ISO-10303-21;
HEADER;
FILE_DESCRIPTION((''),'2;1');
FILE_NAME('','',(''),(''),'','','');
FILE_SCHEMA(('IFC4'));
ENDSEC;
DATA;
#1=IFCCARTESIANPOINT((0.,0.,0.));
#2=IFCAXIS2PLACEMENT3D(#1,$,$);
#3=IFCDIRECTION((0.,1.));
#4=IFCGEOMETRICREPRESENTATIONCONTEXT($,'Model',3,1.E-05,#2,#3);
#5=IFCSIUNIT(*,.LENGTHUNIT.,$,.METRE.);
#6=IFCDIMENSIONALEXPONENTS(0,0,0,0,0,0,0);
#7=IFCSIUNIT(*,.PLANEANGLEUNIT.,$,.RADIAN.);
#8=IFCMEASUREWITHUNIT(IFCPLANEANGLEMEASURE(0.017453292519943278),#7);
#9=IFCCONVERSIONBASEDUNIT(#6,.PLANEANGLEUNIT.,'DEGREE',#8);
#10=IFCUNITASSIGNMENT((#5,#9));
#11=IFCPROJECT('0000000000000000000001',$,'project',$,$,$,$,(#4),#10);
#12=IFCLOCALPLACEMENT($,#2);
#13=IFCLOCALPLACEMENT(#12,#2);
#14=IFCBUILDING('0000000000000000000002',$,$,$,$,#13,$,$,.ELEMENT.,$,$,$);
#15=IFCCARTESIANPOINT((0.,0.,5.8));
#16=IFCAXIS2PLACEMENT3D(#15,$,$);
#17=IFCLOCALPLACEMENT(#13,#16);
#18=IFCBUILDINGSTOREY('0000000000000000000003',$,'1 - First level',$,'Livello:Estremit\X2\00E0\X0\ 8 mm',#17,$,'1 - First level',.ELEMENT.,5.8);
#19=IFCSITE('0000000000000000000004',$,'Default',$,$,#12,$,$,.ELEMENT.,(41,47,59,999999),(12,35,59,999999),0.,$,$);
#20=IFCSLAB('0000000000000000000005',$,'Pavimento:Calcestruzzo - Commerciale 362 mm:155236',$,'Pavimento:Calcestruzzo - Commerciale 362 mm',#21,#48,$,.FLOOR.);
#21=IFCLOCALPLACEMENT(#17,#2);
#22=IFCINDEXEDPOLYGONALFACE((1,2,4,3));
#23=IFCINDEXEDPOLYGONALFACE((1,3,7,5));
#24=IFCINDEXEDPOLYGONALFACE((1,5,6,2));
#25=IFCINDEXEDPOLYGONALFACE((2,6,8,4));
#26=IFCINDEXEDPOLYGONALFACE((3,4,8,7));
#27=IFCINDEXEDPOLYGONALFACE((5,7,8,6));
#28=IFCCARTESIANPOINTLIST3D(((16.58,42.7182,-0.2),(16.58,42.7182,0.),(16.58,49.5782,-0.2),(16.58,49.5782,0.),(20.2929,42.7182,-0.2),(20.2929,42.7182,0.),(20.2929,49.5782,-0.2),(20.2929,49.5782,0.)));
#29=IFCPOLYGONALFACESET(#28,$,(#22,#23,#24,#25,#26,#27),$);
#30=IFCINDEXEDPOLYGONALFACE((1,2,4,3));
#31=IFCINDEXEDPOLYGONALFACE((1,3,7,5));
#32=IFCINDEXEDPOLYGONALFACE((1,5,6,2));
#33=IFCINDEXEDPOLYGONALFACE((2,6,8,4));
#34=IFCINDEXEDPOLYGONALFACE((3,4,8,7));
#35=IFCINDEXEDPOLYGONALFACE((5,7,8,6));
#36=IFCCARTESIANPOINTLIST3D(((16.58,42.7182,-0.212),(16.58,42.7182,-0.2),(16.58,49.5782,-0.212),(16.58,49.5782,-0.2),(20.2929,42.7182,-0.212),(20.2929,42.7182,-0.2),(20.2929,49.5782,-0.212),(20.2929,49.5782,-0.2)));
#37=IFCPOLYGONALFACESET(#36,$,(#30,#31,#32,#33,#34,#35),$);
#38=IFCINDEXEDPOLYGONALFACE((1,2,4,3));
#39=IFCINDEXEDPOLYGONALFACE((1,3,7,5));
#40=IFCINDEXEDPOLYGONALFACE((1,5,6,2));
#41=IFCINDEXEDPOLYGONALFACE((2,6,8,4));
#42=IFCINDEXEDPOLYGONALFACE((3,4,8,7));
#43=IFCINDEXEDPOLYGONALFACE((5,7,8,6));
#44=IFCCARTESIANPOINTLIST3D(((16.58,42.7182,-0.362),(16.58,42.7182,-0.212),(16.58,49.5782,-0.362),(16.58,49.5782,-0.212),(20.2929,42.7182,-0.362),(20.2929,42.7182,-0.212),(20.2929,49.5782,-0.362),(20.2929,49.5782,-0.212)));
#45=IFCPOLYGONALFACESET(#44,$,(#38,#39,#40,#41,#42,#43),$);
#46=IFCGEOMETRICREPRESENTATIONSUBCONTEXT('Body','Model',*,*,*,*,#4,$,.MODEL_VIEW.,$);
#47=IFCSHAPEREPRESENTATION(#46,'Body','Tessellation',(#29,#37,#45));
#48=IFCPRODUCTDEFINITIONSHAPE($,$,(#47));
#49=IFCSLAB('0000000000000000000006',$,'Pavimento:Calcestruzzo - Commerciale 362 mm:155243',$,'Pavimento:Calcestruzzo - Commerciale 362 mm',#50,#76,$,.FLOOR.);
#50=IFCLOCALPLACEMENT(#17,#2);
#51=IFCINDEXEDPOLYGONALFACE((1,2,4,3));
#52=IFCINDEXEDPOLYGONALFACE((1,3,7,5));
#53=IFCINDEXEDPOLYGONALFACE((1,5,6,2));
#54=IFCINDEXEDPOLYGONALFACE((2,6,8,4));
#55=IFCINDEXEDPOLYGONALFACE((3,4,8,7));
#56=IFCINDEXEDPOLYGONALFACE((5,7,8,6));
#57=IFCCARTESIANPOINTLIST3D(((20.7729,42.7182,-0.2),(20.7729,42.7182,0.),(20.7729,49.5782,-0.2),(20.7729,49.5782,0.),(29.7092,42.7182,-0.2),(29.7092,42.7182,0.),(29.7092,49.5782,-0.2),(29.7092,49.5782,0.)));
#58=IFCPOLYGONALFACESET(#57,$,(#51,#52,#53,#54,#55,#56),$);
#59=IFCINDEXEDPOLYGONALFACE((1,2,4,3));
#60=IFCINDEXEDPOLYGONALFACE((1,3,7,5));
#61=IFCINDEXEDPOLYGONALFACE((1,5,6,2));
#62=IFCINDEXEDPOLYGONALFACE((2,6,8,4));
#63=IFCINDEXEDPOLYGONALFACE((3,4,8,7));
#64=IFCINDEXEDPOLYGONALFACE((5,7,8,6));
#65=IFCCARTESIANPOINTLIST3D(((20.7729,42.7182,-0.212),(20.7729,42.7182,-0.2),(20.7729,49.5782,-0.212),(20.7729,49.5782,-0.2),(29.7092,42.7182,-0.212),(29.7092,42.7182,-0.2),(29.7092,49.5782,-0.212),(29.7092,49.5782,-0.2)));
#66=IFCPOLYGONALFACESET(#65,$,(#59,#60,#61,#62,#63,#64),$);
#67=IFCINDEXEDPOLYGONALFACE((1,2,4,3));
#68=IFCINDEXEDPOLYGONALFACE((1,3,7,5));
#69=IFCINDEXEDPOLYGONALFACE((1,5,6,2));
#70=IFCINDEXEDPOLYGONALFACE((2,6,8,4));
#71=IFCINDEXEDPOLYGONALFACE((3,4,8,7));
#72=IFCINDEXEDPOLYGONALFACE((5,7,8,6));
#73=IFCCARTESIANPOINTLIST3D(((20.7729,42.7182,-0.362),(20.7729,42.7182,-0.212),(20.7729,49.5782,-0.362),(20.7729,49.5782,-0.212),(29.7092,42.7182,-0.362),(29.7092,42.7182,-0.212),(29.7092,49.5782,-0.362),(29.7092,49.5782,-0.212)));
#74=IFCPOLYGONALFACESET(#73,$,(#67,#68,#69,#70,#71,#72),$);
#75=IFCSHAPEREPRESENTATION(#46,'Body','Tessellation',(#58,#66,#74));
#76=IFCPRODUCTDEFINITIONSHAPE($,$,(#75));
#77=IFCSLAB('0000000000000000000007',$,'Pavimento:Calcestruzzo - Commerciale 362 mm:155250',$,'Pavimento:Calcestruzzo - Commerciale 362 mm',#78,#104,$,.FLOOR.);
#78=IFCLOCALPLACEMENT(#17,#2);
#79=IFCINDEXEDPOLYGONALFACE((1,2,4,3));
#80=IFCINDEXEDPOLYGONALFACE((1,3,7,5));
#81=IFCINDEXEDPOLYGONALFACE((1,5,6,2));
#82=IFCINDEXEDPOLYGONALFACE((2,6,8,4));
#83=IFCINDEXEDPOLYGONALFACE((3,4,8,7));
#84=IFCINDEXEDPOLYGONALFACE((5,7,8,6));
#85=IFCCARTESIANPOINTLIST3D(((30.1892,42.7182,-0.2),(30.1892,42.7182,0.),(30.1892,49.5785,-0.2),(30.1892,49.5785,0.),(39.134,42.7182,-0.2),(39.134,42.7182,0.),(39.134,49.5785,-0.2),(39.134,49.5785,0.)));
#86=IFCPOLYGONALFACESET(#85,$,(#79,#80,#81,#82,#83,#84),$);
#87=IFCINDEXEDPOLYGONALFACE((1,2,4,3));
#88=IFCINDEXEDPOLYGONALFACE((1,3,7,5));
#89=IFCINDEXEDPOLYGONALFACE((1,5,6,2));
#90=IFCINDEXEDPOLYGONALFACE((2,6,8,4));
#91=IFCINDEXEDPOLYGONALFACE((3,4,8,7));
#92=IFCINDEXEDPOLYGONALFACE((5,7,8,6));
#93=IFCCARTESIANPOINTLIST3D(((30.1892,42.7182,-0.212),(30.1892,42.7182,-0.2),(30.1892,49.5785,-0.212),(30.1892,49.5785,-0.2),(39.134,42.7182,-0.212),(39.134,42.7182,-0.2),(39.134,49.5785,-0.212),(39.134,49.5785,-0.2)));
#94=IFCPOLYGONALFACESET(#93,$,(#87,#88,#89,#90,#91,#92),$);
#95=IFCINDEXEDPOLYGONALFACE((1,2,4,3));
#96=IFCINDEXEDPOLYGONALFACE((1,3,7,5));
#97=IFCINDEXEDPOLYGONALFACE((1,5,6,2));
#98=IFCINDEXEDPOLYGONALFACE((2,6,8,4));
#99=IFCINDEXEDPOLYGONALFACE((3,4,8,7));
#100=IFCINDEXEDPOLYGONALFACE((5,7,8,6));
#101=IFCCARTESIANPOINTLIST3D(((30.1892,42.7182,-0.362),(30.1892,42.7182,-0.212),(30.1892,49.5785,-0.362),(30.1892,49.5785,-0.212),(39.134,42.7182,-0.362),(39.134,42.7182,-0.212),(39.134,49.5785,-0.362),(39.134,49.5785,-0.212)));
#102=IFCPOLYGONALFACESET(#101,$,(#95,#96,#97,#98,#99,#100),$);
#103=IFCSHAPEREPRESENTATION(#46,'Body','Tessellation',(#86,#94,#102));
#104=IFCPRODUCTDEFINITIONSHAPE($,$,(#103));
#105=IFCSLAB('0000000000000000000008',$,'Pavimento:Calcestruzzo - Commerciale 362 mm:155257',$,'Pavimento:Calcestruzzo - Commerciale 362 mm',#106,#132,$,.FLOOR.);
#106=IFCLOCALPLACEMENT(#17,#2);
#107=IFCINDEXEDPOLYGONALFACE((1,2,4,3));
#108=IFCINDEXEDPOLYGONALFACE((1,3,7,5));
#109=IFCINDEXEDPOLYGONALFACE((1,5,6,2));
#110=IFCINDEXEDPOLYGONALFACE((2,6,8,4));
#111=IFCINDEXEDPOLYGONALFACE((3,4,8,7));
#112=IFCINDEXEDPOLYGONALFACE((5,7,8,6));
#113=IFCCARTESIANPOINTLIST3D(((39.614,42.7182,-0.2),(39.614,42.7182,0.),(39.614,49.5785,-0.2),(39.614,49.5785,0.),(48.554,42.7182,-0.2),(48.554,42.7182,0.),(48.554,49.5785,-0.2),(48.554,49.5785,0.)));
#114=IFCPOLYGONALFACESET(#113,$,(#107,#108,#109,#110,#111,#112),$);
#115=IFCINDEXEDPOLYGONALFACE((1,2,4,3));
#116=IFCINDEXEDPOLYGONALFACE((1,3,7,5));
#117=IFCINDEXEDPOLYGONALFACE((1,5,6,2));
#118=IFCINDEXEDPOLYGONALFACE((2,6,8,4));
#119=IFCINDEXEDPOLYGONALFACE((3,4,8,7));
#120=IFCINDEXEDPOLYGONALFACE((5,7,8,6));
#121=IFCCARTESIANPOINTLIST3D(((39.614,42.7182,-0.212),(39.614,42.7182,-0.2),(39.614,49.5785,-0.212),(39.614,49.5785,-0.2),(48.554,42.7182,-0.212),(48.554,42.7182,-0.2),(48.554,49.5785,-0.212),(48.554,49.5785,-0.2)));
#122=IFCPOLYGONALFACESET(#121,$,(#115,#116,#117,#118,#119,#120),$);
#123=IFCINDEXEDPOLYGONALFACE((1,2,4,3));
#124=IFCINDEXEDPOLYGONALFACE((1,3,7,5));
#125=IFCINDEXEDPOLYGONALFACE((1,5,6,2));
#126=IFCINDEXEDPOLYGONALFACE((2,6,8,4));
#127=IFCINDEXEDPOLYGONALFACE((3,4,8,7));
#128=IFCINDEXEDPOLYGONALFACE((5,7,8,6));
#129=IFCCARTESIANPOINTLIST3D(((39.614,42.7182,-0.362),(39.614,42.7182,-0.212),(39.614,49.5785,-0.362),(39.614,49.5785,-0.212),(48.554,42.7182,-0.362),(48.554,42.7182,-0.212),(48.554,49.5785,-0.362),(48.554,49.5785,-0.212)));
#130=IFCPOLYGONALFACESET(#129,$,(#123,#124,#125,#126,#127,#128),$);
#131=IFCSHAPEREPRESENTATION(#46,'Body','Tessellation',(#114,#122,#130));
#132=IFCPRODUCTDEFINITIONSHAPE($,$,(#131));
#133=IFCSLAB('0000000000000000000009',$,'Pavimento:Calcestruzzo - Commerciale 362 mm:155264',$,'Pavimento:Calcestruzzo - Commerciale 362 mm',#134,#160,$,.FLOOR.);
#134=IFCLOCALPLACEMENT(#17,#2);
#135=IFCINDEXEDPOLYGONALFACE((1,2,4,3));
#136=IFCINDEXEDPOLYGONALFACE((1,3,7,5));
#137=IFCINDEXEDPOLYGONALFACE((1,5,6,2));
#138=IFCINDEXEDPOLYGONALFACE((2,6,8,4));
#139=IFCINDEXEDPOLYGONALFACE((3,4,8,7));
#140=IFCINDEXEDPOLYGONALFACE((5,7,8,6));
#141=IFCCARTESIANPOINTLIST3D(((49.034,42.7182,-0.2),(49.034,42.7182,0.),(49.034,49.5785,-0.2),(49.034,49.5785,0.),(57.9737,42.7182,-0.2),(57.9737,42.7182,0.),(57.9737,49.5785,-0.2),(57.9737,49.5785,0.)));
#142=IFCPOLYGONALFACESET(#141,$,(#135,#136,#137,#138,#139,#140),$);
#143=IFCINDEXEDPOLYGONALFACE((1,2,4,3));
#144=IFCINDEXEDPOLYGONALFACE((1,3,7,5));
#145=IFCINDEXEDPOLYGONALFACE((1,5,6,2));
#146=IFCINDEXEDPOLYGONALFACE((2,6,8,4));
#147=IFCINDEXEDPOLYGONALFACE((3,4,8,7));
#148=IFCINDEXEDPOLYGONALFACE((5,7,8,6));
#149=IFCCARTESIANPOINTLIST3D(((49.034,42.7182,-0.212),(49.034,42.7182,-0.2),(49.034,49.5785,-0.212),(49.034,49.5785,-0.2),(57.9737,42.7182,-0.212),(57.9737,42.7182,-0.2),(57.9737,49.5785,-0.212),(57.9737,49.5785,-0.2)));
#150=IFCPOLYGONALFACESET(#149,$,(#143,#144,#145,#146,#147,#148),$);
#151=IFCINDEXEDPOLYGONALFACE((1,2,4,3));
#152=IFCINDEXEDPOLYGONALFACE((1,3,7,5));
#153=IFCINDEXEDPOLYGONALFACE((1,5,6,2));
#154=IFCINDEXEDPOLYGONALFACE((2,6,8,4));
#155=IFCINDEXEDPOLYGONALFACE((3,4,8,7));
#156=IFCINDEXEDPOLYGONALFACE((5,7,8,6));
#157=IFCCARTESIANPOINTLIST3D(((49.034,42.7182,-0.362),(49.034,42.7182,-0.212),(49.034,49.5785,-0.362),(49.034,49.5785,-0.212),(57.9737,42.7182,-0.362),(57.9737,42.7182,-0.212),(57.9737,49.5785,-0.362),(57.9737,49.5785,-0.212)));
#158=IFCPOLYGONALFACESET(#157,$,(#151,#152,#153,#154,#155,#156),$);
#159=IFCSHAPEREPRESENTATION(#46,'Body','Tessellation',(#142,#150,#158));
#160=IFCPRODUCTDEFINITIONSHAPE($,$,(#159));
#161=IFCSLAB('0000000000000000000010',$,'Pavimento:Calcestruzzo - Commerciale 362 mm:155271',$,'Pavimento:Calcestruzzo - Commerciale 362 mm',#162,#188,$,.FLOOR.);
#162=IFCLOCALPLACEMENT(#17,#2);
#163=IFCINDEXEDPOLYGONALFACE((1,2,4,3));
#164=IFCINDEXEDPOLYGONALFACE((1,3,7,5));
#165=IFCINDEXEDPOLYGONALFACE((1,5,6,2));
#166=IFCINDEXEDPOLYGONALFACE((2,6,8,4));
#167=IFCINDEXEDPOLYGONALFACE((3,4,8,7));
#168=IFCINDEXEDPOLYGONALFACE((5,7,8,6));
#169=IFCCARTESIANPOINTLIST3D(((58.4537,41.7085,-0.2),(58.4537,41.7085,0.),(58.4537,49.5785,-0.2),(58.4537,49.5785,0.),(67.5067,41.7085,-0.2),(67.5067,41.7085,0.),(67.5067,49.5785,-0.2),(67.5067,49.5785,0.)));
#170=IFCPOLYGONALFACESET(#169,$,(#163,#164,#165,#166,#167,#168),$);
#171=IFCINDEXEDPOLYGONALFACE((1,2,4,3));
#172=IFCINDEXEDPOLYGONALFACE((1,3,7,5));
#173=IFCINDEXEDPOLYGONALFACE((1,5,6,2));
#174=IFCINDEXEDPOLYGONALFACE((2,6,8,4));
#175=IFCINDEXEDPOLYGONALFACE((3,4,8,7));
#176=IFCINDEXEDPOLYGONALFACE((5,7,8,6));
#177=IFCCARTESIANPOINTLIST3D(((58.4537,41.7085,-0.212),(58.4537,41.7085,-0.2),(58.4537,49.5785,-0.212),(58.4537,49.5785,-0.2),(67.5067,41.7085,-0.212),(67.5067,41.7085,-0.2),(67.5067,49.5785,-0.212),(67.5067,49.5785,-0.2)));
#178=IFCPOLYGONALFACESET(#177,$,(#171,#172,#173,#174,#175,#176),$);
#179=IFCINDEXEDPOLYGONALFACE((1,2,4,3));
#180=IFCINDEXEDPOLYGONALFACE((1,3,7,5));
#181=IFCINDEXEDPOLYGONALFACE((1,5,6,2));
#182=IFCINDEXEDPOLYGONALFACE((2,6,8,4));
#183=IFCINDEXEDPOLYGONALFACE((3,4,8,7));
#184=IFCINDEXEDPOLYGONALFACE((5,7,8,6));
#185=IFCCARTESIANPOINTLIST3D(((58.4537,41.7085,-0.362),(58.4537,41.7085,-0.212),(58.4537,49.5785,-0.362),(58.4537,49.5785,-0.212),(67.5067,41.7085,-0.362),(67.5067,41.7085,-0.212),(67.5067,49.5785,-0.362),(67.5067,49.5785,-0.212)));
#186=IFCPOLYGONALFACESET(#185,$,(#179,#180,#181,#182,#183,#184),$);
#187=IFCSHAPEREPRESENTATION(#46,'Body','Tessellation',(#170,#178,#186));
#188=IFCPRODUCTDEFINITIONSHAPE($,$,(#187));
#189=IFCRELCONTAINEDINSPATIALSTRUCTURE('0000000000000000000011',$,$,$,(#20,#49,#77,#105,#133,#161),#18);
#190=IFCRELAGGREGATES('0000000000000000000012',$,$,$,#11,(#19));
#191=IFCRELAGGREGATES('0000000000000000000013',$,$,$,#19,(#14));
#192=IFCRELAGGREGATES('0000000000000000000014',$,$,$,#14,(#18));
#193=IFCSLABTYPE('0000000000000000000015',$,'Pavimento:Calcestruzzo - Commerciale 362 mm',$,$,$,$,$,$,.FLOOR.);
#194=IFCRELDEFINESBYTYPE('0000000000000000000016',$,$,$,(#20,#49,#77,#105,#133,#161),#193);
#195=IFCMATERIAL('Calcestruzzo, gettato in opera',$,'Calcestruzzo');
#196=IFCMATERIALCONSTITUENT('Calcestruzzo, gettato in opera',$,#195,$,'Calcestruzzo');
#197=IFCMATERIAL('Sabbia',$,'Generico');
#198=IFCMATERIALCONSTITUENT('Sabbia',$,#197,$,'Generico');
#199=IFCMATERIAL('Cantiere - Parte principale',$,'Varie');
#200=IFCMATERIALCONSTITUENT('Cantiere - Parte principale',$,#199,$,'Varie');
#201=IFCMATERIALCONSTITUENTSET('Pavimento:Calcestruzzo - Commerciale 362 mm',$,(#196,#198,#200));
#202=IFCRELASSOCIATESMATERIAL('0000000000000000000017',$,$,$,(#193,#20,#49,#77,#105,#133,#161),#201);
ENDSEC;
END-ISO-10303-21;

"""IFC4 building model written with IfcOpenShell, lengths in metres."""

from ifc_helpers import new_model, entity, si_unit, converted_unit, direction, frame, origin, place, context, subcontext, project, spatial, indexed_curve, outline, extrude, material, constituent, constituent_set, type_object, element, save


model = new_model("IFC4")

# Units and contexts
model_context = context("Model", 3, precision=1e-05, world=origin(), true_north=direction((0.0, 1.0)))
body_context = subcontext(model_context, "Body", "Model", "MODEL_VIEW")
ifc_project = project(units=[si_unit("LENGTHUNIT", "METRE"), converted_unit("PLANEANGLEUNIT", "DEGREE", entity("IfcPlaneAngleMeasure", 0.017453292519943278), si_unit("PLANEANGLEUNIT", "RADIAN"), dimensions=[0, 0, 0, 0, 0, 0, 0])], contexts=[model_context])

# Site, building, storey
site_placement = place(None, origin())
site = spatial("IfcSite", under=ifc_project, at=site_placement, Name="Default", CompositionType="ELEMENT", RefLatitude=(41, 47, 59, 999999), RefLongitude=(12, 35, 59, 999999), RefElevation=0.0)
building_placement = place(site_placement, origin())
building = spatial("IfcBuilding", under=site, at=building_placement, CompositionType="ELEMENT")
storey_placement = place(building_placement, frame((0.0, 0.0, 5.8)))
storey = spatial("IfcBuildingStorey", under=building, at=storey_placement, Name="1 - First level", ObjectType="Livello:Estremità 8 mm", LongName="1 - First level", CompositionType="ELEMENT", Elevation=5.8)

# Slabs
ifc_material_1 = material(Name="Calcestruzzo, gettato in opera", Category="Calcestruzzo")
ifc_constituent_1 = constituent(ifc_material_1, Name="Calcestruzzo, gettato in opera", Category="Calcestruzzo")
ifc_material_2 = material(Name="Sabbia", Category="Generico")
ifc_constituent_2 = constituent(ifc_material_2, Name="Sabbia", Category="Generico")
ifc_material_3 = material(Name="Cantiere - Parte principale", Category="Varie")
ifc_constituent_3 = constituent(ifc_material_3, Name="Cantiere - Parte principale", Category="Varie")
ifc_constituent_set = constituent_set(constituents=[ifc_constituent_1, ifc_constituent_2, ifc_constituent_3], Name="Pavimento:Calcestruzzo - Commerciale 362 mm")
slab_type = type_object("IfcSlabType", Name="Pavimento:Calcestruzzo - Commerciale 362 mm", PredefinedType="FLOOR", material=ifc_constituent_set)
slab_1_placement = place(storey_placement, origin())
element("IfcSlab", 1, at=slab_1_placement, inside=storey, type_object=slab_type, material=ifc_constituent_set, Name="Pavimento:Calcestruzzo - Commerciale 362 mm:155236", ObjectType="Pavimento:Calcestruzzo - Commerciale 362 mm", PredefinedType="FLOOR", context=body_context, shape_type="SweptSolid", body=[
    extrude(outline(indexed_curve([(-1.8565, -3.43), (1.8565, -3.43), (1.8565, 3.43), (-1.8565, 3.43), (-1.8565, -3.43)], self_intersect=False)), frame((18.4365, 46.1482, -0.2), z_axis=(0.0, 0.0, 1.0), x_axis=(-1.0, 0.0, 0.0)), (0.0, 0.0, 1.0), 0.2),
    extrude(outline(indexed_curve([(-1.8565, -3.43), (1.8565, -3.43), (1.8565, 3.43), (-1.8565, 3.43), (-1.8565, -3.43)], self_intersect=False)), frame((18.4365, 46.1482, -0.212), z_axis=(0.0, 0.0, 1.0), x_axis=(-1.0, 0.0, 0.0)), (0.0, 0.0, 1.0), 0.012),
    extrude(outline(indexed_curve([(-1.8565, -3.43), (1.8565, -3.43), (1.8565, 3.43), (-1.8565, 3.43), (-1.8565, -3.43)], self_intersect=False)), frame((18.4365, 46.1482, -0.362), z_axis=(0.0, 0.0, 1.0), x_axis=(-1.0, 0.0, 0.0)), (0.0, 0.0, 1.0), 0.15),
])
slab_2_placement = place(storey_placement, origin())
element("IfcSlab", 2, at=slab_2_placement, inside=storey, type_object=slab_type, material=ifc_constituent_set, Name="Pavimento:Calcestruzzo - Commerciale 362 mm:155243", ObjectType="Pavimento:Calcestruzzo - Commerciale 362 mm", PredefinedType="FLOOR", context=body_context, shape_type="SweptSolid", body=[
    extrude(outline(indexed_curve([(-3.43, -4.4681), (3.43, -4.4681), (3.43, 4.4681), (-3.43, 4.4681), (-3.43, -4.4681)], self_intersect=False)), frame((25.2411, 46.1482, -0.2), z_axis=(0.0, 0.0, 1.0), x_axis=(0.0, -1.0, 0.0)), (0.0, 0.0, 1.0), 0.2),
    extrude(outline(indexed_curve([(-3.43, -4.4681), (3.43, -4.4681), (3.43, 4.4681), (-3.43, 4.4681), (-3.43, -4.4681)], self_intersect=False)), frame((25.2411, 46.1482, -0.212), z_axis=(0.0, 0.0, 1.0), x_axis=(0.0, -1.0, 0.0)), (0.0, 0.0, 1.0), 0.012),
    extrude(outline(indexed_curve([(-3.43, -4.4681), (3.43, -4.4681), (3.43, 4.4681), (-3.43, 4.4681), (-3.43, -4.4681)], self_intersect=False)), frame((25.2411, 46.1482, -0.362), z_axis=(0.0, 0.0, 1.0), x_axis=(0.0, -1.0, 0.0)), (0.0, 0.0, 1.0), 0.15),
])
slab_3_placement = place(storey_placement, origin())
element("IfcSlab", 3, at=slab_3_placement, inside=storey, type_object=slab_type, material=ifc_constituent_set, Name="Pavimento:Calcestruzzo - Commerciale 362 mm:155250", ObjectType="Pavimento:Calcestruzzo - Commerciale 362 mm", PredefinedType="FLOOR", context=body_context, shape_type="SweptSolid", body=[
    extrude(outline(indexed_curve([(-3.4302, -4.4724), (3.4302, -4.4724), (3.4302, 4.4724), (-3.4302, 4.4724), (-3.4302, -4.4724)], self_intersect=False)), frame((34.6616, 46.1483, -0.2), z_axis=(0.0, 0.0, 1.0), x_axis=(0.0, -1.0, 0.0)), (0.0, 0.0, 1.0), 0.2),
    extrude(outline(indexed_curve([(-3.4302, -4.4724), (3.4302, -4.4724), (3.4302, 4.4724), (-3.4302, 4.4724), (-3.4302, -4.4724)], self_intersect=False)), frame((34.6616, 46.1483, -0.212), z_axis=(0.0, 0.0, 1.0), x_axis=(0.0, -1.0, 0.0)), (0.0, 0.0, 1.0), 0.012),
    extrude(outline(indexed_curve([(-3.4302, -4.4724), (3.4302, -4.4724), (3.4302, 4.4724), (-3.4302, 4.4724), (-3.4302, -4.4724)], self_intersect=False)), frame((34.6616, 46.1483, -0.362), z_axis=(0.0, 0.0, 1.0), x_axis=(0.0, -1.0, 0.0)), (0.0, 0.0, 1.0), 0.15),
])
slab_4_placement = place(storey_placement, origin())
element("IfcSlab", 4, at=slab_4_placement, inside=storey, type_object=slab_type, material=ifc_constituent_set, Name="Pavimento:Calcestruzzo - Commerciale 362 mm:155257", ObjectType="Pavimento:Calcestruzzo - Commerciale 362 mm", PredefinedType="FLOOR", context=body_context, shape_type="SweptSolid", body=[
    extrude(outline(indexed_curve([(-3.4302, -4.47), (3.4302, -4.47), (3.4302, 4.47), (-3.4302, 4.47), (-3.4302, -4.47)], self_intersect=False)), frame((44.084, 46.1483, -0.2), z_axis=(0.0, 0.0, 1.0), x_axis=(0.0, -1.0, 0.0)), (0.0, 0.0, 1.0), 0.2),
    extrude(outline(indexed_curve([(-3.4302, -4.47), (3.4302, -4.47), (3.4302, 4.47), (-3.4302, 4.47), (-3.4302, -4.47)], self_intersect=False)), frame((44.084, 46.1483, -0.212), z_axis=(0.0, 0.0, 1.0), x_axis=(0.0, -1.0, 0.0)), (0.0, 0.0, 1.0), 0.012),
    extrude(outline(indexed_curve([(-3.4302, -4.47), (3.4302, -4.47), (3.4302, 4.47), (-3.4302, 4.47), (-3.4302, -4.47)], self_intersect=False)), frame((44.084, 46.1483, -0.362), z_axis=(0.0, 0.0, 1.0), x_axis=(0.0, -1.0, 0.0)), (0.0, 0.0, 1.0), 0.15),
])
slab_5_placement = place(storey_placement, origin())
element("IfcSlab", 5, at=slab_5_placement, inside=storey, type_object=slab_type, material=ifc_constituent_set, Name="Pavimento:Calcestruzzo - Commerciale 362 mm:155264", ObjectType="Pavimento:Calcestruzzo - Commerciale 362 mm", PredefinedType="FLOOR", context=body_context, shape_type="SweptSolid", body=[
    extrude(outline(indexed_curve([(-3.4302, -4.4698), (3.4302, -4.4698), (3.4302, 4.4698), (-3.4302, 4.4698), (-3.4302, -4.4698)], self_intersect=False)), frame((53.5038, 46.1483, -0.2), z_axis=(0.0, 0.0, 1.0), x_axis=(0.0, -1.0, 0.0)), (0.0, 0.0, 1.0), 0.2),
    extrude(outline(indexed_curve([(-3.4302, -4.4698), (3.4302, -4.4698), (3.4302, 4.4698), (-3.4302, 4.4698), (-3.4302, -4.4698)], self_intersect=False)), frame((53.5038, 46.1483, -0.212), z_axis=(0.0, 0.0, 1.0), x_axis=(0.0, -1.0, 0.0)), (0.0, 0.0, 1.0), 0.012),
    extrude(outline(indexed_curve([(-3.4302, -4.4698), (3.4302, -4.4698), (3.4302, 4.4698), (-3.4302, 4.4698), (-3.4302, -4.4698)], self_intersect=False)), frame((53.5038, 46.1483, -0.362), z_axis=(0.0, 0.0, 1.0), x_axis=(0.0, -1.0, 0.0)), (0.0, 0.0, 1.0), 0.15),
])
slab_6_placement = place(storey_placement, origin())
element("IfcSlab", 6, at=slab_6_placement, inside=storey, type_object=slab_type, material=ifc_constituent_set, Name="Pavimento:Calcestruzzo - Commerciale 362 mm:155271", ObjectType="Pavimento:Calcestruzzo - Commerciale 362 mm", PredefinedType="FLOOR", context=body_context, shape_type="SweptSolid", body=[
    extrude(outline(indexed_curve([(-4.5265, -3.935), (4.5265, -3.935), (4.5265, 3.935), (-4.5265, 3.935), (-4.5265, -3.935)], self_intersect=False)), frame((62.9802, 45.6435, -0.2)), (0.0, 0.0, 1.0), 0.2),
    extrude(outline(indexed_curve([(-4.5265, -3.935), (4.5265, -3.935), (4.5265, 3.935), (-4.5265, 3.935), (-4.5265, -3.935)], self_intersect=False)), frame((62.9802, 45.6435, -0.212)), (0.0, 0.0, 1.0), 0.012),
    extrude(outline(indexed_curve([(-4.5265, -3.935), (4.5265, -3.935), (4.5265, 3.935), (-4.5265, 3.935), (-4.5265, -3.935)], self_intersect=False)), frame((62.9802, 45.6435, -0.362)), (0.0, 0.0, 1.0), 0.15),
])

save(model, "model.ifc")
